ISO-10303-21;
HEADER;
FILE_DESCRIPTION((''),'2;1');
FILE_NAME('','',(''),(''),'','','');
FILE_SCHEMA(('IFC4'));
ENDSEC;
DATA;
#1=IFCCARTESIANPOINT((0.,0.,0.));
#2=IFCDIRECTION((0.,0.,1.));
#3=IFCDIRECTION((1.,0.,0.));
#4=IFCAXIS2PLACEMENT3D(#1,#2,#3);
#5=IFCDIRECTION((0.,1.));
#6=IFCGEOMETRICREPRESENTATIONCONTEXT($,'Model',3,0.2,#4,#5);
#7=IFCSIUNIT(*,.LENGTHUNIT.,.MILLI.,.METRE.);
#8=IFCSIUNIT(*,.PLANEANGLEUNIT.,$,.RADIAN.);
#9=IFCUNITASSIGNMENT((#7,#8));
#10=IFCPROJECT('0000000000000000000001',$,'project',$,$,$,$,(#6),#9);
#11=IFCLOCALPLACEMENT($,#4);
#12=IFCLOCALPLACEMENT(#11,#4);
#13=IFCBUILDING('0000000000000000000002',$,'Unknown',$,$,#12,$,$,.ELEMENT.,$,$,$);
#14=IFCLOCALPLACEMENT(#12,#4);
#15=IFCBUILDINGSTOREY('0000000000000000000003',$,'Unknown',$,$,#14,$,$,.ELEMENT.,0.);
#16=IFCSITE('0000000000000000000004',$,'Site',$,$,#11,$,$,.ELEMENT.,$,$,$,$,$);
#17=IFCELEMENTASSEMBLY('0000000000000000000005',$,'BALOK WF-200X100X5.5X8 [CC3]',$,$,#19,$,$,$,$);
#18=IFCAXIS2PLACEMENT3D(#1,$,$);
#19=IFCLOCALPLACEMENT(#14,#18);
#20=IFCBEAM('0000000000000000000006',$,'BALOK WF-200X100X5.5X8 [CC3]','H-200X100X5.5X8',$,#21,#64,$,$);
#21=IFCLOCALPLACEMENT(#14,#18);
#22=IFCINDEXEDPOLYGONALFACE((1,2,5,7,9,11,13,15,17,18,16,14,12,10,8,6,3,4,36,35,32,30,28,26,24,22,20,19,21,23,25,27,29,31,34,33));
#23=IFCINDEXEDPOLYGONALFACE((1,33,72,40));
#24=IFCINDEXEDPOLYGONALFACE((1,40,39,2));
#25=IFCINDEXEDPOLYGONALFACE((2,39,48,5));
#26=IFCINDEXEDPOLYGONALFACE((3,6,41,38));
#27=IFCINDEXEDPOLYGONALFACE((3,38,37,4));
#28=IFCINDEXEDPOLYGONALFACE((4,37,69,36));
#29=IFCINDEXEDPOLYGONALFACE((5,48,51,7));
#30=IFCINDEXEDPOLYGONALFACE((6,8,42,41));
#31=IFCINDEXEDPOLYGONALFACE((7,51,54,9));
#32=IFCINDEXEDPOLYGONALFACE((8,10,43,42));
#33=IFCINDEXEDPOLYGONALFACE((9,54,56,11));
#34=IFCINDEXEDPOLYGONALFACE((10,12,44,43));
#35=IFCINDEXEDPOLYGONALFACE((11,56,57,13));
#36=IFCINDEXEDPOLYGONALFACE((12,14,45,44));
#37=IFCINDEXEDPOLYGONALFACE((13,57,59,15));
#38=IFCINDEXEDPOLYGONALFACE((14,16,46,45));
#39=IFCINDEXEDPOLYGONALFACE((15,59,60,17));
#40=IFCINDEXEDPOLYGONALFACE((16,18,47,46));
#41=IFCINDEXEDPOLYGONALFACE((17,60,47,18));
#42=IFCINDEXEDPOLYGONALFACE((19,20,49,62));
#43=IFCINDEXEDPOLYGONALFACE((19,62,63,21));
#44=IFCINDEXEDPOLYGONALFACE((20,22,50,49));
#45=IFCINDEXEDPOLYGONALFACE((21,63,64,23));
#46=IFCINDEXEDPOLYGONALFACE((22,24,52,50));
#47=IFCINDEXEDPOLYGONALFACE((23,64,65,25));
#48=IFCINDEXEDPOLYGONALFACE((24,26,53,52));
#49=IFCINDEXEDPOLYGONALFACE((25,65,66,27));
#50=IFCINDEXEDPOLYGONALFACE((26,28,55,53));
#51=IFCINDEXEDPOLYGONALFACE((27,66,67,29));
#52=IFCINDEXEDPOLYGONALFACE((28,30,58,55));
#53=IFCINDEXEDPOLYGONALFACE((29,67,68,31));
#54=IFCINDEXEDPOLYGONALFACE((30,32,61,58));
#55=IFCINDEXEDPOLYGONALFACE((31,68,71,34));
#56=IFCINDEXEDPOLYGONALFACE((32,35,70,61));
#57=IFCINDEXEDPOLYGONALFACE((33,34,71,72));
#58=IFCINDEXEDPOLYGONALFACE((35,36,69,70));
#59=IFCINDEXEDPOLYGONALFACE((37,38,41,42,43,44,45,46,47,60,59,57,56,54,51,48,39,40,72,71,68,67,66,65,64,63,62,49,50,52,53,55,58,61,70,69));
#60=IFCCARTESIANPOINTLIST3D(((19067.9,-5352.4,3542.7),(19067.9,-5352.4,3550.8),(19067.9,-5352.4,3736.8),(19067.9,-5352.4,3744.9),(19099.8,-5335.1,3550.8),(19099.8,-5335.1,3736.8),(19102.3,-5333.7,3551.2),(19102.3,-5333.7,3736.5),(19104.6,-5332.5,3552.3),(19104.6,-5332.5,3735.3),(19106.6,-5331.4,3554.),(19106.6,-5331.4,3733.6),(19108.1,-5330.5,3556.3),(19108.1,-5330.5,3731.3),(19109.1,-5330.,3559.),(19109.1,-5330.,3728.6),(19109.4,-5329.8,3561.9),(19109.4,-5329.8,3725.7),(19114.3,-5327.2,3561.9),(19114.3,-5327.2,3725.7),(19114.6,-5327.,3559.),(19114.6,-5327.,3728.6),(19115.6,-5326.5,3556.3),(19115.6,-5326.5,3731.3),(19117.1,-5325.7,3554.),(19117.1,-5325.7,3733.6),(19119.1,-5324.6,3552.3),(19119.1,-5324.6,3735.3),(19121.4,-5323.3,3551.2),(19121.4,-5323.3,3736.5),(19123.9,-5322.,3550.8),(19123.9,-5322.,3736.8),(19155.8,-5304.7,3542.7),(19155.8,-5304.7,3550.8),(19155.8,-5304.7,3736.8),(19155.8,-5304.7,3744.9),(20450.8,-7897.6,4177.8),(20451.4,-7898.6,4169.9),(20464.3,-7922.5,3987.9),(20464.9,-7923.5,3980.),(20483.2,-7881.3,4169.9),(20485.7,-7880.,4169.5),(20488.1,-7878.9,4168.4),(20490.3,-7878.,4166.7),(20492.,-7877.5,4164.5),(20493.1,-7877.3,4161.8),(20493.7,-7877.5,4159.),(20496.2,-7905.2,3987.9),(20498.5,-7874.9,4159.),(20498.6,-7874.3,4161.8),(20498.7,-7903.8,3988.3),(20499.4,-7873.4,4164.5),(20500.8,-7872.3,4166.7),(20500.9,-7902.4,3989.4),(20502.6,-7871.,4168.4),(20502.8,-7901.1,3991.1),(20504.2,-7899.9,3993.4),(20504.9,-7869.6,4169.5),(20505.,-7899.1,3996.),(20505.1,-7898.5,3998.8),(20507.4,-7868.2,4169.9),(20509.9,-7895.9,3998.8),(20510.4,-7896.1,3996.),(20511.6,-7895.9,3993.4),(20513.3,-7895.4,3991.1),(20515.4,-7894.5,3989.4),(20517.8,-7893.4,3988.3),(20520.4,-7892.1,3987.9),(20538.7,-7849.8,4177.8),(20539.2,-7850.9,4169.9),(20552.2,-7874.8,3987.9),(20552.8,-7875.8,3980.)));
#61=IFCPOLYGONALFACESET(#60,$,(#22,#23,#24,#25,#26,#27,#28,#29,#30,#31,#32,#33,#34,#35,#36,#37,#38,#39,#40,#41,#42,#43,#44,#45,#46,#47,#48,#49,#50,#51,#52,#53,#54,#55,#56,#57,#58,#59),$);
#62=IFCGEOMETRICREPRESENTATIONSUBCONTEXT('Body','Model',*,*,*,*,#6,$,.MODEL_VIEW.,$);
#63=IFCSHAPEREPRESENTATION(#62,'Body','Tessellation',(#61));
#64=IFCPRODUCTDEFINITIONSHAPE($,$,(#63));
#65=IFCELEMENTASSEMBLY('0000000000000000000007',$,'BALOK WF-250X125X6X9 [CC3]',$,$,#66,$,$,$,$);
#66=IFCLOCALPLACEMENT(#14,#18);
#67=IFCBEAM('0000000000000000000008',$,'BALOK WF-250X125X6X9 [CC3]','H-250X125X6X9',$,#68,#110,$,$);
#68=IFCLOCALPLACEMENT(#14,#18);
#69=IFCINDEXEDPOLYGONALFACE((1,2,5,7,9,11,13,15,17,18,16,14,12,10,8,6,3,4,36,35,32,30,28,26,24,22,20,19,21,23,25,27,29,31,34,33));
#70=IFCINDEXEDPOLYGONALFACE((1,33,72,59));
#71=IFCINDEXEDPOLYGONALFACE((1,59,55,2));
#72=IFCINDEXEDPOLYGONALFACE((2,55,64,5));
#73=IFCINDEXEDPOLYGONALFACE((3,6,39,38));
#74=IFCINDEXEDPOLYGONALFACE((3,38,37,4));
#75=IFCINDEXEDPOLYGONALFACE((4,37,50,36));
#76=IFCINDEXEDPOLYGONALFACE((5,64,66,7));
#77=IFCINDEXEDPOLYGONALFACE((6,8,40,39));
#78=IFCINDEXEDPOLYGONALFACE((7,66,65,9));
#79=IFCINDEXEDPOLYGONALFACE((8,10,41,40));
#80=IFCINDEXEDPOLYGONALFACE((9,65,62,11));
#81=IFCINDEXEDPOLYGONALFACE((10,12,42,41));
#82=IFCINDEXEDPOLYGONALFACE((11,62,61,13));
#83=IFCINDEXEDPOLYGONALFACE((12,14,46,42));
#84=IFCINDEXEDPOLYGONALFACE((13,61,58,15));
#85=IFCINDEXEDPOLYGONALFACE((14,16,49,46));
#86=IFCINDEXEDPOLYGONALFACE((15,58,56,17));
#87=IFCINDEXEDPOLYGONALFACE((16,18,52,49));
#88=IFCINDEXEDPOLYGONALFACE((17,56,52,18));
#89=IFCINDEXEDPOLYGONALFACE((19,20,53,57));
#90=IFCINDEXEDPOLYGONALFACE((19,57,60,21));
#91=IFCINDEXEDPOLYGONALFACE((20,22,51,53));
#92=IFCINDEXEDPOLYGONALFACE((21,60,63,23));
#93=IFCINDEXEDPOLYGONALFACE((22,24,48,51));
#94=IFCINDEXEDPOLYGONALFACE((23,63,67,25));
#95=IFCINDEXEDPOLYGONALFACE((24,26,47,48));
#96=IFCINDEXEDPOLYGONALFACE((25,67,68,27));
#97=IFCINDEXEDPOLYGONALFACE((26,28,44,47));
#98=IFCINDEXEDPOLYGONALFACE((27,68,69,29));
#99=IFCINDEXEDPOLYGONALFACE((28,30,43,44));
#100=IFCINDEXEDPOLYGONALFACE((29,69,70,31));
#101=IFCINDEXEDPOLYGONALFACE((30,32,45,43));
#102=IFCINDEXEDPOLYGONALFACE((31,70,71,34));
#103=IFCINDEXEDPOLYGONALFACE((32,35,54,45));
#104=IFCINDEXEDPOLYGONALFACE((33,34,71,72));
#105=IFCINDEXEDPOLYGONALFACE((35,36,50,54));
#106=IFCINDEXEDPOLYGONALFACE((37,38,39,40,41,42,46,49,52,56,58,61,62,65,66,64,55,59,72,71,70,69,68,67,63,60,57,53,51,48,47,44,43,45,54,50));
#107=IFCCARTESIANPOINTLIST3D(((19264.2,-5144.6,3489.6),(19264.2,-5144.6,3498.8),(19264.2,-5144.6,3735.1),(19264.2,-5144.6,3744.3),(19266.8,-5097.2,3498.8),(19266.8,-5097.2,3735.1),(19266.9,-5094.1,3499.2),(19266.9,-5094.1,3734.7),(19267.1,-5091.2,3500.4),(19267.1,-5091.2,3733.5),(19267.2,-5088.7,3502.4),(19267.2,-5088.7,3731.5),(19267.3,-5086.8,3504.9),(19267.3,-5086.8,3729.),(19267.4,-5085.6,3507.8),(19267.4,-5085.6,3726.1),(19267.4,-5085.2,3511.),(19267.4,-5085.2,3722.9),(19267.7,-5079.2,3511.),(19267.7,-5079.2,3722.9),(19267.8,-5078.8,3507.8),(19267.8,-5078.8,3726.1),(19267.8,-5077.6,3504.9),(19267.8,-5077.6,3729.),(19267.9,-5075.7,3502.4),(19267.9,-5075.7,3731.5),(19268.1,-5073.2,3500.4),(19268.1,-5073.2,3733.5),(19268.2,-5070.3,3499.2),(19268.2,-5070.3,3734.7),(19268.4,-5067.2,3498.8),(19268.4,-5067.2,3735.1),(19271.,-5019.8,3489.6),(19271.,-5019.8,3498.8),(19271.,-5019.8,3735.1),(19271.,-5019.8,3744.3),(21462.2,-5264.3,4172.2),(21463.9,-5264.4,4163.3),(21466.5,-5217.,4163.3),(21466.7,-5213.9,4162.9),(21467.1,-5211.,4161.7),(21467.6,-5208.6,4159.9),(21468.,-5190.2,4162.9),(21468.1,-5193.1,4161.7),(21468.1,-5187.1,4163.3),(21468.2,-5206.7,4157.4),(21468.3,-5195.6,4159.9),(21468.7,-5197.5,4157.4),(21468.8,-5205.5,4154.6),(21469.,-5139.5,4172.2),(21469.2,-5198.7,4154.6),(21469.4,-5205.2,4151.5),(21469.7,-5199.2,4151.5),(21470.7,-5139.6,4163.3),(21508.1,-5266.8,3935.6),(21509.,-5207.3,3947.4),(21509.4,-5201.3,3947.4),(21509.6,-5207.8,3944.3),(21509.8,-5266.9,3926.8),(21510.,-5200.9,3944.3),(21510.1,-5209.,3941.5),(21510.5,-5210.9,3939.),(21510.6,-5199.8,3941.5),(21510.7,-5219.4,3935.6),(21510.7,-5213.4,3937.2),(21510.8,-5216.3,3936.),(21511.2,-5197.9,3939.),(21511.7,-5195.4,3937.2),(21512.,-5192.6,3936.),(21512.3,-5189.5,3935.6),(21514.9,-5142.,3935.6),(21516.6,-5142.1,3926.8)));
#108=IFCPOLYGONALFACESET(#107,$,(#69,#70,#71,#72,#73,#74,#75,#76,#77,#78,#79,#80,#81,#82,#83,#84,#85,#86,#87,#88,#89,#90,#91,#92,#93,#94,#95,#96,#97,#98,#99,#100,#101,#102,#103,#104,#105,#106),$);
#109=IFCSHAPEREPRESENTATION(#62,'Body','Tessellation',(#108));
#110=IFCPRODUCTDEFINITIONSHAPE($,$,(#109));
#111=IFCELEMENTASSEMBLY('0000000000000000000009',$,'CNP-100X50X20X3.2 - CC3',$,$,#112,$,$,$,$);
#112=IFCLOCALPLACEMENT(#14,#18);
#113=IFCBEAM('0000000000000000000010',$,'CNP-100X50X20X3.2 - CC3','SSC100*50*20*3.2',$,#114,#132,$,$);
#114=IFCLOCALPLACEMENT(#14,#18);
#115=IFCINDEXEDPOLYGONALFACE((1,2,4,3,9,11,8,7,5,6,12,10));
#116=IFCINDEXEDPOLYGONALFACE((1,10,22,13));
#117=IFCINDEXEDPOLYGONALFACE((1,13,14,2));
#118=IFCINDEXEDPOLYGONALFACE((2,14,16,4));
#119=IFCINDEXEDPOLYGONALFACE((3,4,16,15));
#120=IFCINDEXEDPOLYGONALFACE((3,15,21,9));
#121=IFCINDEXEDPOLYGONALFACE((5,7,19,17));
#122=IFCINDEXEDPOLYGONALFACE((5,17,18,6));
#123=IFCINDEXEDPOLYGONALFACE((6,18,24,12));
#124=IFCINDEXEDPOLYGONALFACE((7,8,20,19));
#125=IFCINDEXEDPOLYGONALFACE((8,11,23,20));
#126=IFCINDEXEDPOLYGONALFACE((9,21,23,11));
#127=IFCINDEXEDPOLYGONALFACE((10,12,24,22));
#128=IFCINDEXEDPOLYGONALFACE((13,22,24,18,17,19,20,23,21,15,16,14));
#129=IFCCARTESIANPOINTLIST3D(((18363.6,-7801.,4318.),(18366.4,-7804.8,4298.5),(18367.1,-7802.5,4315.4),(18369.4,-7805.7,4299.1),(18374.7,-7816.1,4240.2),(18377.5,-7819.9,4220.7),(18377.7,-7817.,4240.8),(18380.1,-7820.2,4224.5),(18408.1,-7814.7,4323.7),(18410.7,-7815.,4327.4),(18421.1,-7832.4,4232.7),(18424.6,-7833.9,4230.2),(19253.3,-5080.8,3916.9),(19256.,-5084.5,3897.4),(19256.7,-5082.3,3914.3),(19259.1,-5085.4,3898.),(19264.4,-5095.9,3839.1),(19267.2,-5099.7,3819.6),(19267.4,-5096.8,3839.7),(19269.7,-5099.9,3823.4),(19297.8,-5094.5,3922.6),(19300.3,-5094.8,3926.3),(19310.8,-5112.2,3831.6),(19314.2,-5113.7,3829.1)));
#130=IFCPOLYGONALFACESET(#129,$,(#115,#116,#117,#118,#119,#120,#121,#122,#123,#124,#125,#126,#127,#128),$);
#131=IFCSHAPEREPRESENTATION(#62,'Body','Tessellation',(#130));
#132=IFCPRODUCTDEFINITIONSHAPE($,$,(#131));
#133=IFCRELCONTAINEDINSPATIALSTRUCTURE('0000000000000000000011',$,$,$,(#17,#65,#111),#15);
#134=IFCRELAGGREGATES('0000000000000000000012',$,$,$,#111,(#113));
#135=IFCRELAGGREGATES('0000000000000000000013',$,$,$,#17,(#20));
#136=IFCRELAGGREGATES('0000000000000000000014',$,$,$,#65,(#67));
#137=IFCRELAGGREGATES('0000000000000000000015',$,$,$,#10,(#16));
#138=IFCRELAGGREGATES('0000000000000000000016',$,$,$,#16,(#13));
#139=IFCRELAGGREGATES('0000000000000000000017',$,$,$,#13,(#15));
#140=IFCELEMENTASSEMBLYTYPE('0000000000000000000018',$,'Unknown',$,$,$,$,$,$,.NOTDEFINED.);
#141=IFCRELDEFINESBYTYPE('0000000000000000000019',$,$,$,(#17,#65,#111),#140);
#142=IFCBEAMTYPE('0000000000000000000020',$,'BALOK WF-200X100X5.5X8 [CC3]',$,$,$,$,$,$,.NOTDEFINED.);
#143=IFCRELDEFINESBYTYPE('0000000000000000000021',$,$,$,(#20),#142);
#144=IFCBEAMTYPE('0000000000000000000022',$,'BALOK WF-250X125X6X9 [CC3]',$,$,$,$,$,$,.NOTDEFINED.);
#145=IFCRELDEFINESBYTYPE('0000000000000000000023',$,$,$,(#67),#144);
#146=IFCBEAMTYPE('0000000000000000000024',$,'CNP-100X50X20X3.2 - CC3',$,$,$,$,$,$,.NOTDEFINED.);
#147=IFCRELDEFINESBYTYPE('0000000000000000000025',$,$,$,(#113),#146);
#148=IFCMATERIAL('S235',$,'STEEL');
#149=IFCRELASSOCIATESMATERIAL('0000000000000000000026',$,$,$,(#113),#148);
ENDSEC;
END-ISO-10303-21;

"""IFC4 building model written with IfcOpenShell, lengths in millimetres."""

from ifc_helpers import new_model, si_unit, direction, frame, origin_with_axes, origin_2d_with_axis, place, context, subcontext, project, spatial, i_section, c_section, extrude, clip, halfspace, material, material_profile, profile_set, profile_usage, type_object, element, aggregate, save


model = new_model("IFC4")

# Units and contexts
model_context = context("Model", 3, precision=0.2, world=origin_with_axes(), true_north=direction((0.0, 1.0)))
body_context = subcontext(model_context, "Body", "Model", "MODEL_VIEW")
ifc_project = project(units=[si_unit("LENGTHUNIT", "METRE", prefix="MILLI"), si_unit("PLANEANGLEUNIT", "RADIAN")], contexts=[model_context])

# Site, building, storey
site_placement = place(None, origin_with_axes())
site = spatial("IfcSite", under=ifc_project, at=site_placement, Name="Site", CompositionType="ELEMENT")
building_placement = place(site_placement, origin_with_axes())
building = spatial("IfcBuilding", under=site, at=building_placement, Name="Unknown", CompositionType="ELEMENT")
storey_placement = place(building_placement, origin_with_axes())
storey = spatial("IfcBuildingStorey", under=building, at=storey_placement, Name="Unknown", CompositionType="ELEMENT", Elevation=0.0)

# Element assemblies, beams
element_assembly_type = type_object("IfcElementAssemblyType", Name="Unknown", PredefinedType="NOTDEFINED")
assembly_1_placement = place(storey_placement, frame((19081.2, -5272.1, 3634.2), z_axis=(-0.878678, -0.477415, 0.0), x_axis=(0.472171, -0.869027, 0.147809)))
assembly_1 = element("IfcElementAssembly", 1, at=assembly_1_placement, inside=storey, type_object=element_assembly_type, Name="BALOK WF-200X100X5.5X8 [CC3]")
beam_type_1 = type_object("IfcBeamType", Name="BALOK WF-200X100X5.5X8 [CC3]", PredefinedType="NOTDEFINED")
beam_1_placement = place(assembly_1_placement, origin_with_axes())
beam_1 = element("IfcBeam", 2, at=beam_1_placement, type_object=beam_type_1, Name="BALOK WF-200X100X5.5X8 [CC3]", Description="H-200X100X5.5X8", context=body_context, shape_type="Clipping", body=[
    clip(clip(extrude(i_section(OverallWidth=100.0, OverallDepth=200.0, WebThickness=5.5, FlangeThickness=8.0, FilletRadius=11.0, FlangeEdgeRadius=0.0, FlangeSlope=0.0, at=origin_2d_with_axis()), frame((0.0, 0.0, 0.0), z_axis=(-1.0, 0.0, 0.0), x_axis=(0.0, 0.0, 1.0)), (0.0, 0.0, -1.0), 3008.6), halfspace(frame((48.0, -100.0, -50.0), z_axis=(-0.989016, 0.147809, -0.000024), x_axis=(-0.000024, 0.0, 1.0)), False)), halfspace(frame((50.0, -100.0, -50.0), z_axis=(-0.989016, 0.147809, -0.000094), x_axis=(-0.000095, 0.0, 1.0)), False)),
])
assembly_2_placement = place(storey_placement, frame((19235.0, -5080.4, 3610.6), z_axis=(-0.05439, -0.99852, 0.0), x_axis=(0.980174, -0.05339, 0.190809)))
assembly_2 = element("IfcElementAssembly", 3, at=assembly_2_placement, inside=storey, type_object=element_assembly_type, Name="BALOK WF-250X125X6X9 [CC3]")
beam_type_2 = type_object("IfcBeamType", Name="BALOK WF-250X125X6X9 [CC3]", PredefinedType="NOTDEFINED")
beam_2_placement = place(assembly_2_placement, origin_with_axes())
beam_2 = element("IfcBeam", 4, at=beam_2_placement, type_object=beam_type_2, Name="BALOK WF-250X125X6X9 [CC3]", Description="H-250X125X6X9", context=body_context, shape_type="Clipping", body=[
    clip(clip(extrude(i_section(OverallWidth=125.0, OverallDepth=250.0, WebThickness=6.0, FlangeThickness=9.0, FilletRadius=12.0, FlangeEdgeRadius=0.0, FlangeSlope=0.0, at=origin_2d_with_axis()), frame((0.0, 0.0, 0.0), z_axis=(-1.0, 0.0, 0.0), x_axis=(0.0, 0.0, 1.0)), (0.0, 0.0, -1.0), 2300.0), halfspace(frame((16.6, -75.0, -50.0), z_axis=(-0.981627, 0.190809, 0.000007), x_axis=(0.000007, 0.0, 1.0)), False)), halfspace(frame((9.0, -125.0, -62.5), z_axis=(-0.981627, 0.190809, 0.000007), x_axis=(0.000007, 0.0, 1.0)), False)),
])
assembly_3_placement = place(storey_placement, frame((19283.7, -5097.2, 3873.0), z_axis=(-0.941228, 0.279971, -0.188962), x_axis=(-0.307844, -0.94126, 0.138789)))
assembly_3 = element("IfcElementAssembly", 5, at=assembly_3_placement, inside=storey, type_object=element_assembly_type, Name="CNP-100X50X20X3.2 - CC3")
ifc_material_1 = material(Name="S235", Category="STEEL")
ifc_material_profile_1 = material_profile(ifc_material_1, c_section(Depth=100.0, Width=50.0, WallThickness=3.2, Girth=20.0, at=origin_2d_with_axis()), Name="SSC100*50*20*3.2")
ifc_profile_set_1 = profile_set([ifc_material_profile_1])
ifc_profile_usage_1 = profile_usage(ifc_profile_set_1, cardinal=3)
beam_type_3 = type_object("IfcBeamType", Name="CNP-100X50X20X3.2 - CC3", PredefinedType="NOTDEFINED")
beam_3_placement = place(assembly_3_placement, origin_with_axes())
beam_3 = element("IfcBeam", 6, at=beam_3_placement, type_object=beam_type_3, material=ifc_profile_usage_1, Name="CNP-100X50X20X3.2 - CC3", Description="SSC100*50*20*3.2", context=body_context, shape_type="SolidModel", body=[
    extrude(c_section(Depth=100.0, Width=50.0, WallThickness=3.2, Girth=20.0, at=origin_2d_with_axis()), frame((0.0, 0.0, 0.0), z_axis=(-1.0, 0.0, 0.0), x_axis=(0.0, 0.0, 1.0)), (0.0, 0.0, -1.0), 2890.0),
])
aggregate(assembly_3, [beam_3])

aggregate(assembly_1, [beam_1])

aggregate(assembly_2, [beam_2])

save(model, "model.ifc")
